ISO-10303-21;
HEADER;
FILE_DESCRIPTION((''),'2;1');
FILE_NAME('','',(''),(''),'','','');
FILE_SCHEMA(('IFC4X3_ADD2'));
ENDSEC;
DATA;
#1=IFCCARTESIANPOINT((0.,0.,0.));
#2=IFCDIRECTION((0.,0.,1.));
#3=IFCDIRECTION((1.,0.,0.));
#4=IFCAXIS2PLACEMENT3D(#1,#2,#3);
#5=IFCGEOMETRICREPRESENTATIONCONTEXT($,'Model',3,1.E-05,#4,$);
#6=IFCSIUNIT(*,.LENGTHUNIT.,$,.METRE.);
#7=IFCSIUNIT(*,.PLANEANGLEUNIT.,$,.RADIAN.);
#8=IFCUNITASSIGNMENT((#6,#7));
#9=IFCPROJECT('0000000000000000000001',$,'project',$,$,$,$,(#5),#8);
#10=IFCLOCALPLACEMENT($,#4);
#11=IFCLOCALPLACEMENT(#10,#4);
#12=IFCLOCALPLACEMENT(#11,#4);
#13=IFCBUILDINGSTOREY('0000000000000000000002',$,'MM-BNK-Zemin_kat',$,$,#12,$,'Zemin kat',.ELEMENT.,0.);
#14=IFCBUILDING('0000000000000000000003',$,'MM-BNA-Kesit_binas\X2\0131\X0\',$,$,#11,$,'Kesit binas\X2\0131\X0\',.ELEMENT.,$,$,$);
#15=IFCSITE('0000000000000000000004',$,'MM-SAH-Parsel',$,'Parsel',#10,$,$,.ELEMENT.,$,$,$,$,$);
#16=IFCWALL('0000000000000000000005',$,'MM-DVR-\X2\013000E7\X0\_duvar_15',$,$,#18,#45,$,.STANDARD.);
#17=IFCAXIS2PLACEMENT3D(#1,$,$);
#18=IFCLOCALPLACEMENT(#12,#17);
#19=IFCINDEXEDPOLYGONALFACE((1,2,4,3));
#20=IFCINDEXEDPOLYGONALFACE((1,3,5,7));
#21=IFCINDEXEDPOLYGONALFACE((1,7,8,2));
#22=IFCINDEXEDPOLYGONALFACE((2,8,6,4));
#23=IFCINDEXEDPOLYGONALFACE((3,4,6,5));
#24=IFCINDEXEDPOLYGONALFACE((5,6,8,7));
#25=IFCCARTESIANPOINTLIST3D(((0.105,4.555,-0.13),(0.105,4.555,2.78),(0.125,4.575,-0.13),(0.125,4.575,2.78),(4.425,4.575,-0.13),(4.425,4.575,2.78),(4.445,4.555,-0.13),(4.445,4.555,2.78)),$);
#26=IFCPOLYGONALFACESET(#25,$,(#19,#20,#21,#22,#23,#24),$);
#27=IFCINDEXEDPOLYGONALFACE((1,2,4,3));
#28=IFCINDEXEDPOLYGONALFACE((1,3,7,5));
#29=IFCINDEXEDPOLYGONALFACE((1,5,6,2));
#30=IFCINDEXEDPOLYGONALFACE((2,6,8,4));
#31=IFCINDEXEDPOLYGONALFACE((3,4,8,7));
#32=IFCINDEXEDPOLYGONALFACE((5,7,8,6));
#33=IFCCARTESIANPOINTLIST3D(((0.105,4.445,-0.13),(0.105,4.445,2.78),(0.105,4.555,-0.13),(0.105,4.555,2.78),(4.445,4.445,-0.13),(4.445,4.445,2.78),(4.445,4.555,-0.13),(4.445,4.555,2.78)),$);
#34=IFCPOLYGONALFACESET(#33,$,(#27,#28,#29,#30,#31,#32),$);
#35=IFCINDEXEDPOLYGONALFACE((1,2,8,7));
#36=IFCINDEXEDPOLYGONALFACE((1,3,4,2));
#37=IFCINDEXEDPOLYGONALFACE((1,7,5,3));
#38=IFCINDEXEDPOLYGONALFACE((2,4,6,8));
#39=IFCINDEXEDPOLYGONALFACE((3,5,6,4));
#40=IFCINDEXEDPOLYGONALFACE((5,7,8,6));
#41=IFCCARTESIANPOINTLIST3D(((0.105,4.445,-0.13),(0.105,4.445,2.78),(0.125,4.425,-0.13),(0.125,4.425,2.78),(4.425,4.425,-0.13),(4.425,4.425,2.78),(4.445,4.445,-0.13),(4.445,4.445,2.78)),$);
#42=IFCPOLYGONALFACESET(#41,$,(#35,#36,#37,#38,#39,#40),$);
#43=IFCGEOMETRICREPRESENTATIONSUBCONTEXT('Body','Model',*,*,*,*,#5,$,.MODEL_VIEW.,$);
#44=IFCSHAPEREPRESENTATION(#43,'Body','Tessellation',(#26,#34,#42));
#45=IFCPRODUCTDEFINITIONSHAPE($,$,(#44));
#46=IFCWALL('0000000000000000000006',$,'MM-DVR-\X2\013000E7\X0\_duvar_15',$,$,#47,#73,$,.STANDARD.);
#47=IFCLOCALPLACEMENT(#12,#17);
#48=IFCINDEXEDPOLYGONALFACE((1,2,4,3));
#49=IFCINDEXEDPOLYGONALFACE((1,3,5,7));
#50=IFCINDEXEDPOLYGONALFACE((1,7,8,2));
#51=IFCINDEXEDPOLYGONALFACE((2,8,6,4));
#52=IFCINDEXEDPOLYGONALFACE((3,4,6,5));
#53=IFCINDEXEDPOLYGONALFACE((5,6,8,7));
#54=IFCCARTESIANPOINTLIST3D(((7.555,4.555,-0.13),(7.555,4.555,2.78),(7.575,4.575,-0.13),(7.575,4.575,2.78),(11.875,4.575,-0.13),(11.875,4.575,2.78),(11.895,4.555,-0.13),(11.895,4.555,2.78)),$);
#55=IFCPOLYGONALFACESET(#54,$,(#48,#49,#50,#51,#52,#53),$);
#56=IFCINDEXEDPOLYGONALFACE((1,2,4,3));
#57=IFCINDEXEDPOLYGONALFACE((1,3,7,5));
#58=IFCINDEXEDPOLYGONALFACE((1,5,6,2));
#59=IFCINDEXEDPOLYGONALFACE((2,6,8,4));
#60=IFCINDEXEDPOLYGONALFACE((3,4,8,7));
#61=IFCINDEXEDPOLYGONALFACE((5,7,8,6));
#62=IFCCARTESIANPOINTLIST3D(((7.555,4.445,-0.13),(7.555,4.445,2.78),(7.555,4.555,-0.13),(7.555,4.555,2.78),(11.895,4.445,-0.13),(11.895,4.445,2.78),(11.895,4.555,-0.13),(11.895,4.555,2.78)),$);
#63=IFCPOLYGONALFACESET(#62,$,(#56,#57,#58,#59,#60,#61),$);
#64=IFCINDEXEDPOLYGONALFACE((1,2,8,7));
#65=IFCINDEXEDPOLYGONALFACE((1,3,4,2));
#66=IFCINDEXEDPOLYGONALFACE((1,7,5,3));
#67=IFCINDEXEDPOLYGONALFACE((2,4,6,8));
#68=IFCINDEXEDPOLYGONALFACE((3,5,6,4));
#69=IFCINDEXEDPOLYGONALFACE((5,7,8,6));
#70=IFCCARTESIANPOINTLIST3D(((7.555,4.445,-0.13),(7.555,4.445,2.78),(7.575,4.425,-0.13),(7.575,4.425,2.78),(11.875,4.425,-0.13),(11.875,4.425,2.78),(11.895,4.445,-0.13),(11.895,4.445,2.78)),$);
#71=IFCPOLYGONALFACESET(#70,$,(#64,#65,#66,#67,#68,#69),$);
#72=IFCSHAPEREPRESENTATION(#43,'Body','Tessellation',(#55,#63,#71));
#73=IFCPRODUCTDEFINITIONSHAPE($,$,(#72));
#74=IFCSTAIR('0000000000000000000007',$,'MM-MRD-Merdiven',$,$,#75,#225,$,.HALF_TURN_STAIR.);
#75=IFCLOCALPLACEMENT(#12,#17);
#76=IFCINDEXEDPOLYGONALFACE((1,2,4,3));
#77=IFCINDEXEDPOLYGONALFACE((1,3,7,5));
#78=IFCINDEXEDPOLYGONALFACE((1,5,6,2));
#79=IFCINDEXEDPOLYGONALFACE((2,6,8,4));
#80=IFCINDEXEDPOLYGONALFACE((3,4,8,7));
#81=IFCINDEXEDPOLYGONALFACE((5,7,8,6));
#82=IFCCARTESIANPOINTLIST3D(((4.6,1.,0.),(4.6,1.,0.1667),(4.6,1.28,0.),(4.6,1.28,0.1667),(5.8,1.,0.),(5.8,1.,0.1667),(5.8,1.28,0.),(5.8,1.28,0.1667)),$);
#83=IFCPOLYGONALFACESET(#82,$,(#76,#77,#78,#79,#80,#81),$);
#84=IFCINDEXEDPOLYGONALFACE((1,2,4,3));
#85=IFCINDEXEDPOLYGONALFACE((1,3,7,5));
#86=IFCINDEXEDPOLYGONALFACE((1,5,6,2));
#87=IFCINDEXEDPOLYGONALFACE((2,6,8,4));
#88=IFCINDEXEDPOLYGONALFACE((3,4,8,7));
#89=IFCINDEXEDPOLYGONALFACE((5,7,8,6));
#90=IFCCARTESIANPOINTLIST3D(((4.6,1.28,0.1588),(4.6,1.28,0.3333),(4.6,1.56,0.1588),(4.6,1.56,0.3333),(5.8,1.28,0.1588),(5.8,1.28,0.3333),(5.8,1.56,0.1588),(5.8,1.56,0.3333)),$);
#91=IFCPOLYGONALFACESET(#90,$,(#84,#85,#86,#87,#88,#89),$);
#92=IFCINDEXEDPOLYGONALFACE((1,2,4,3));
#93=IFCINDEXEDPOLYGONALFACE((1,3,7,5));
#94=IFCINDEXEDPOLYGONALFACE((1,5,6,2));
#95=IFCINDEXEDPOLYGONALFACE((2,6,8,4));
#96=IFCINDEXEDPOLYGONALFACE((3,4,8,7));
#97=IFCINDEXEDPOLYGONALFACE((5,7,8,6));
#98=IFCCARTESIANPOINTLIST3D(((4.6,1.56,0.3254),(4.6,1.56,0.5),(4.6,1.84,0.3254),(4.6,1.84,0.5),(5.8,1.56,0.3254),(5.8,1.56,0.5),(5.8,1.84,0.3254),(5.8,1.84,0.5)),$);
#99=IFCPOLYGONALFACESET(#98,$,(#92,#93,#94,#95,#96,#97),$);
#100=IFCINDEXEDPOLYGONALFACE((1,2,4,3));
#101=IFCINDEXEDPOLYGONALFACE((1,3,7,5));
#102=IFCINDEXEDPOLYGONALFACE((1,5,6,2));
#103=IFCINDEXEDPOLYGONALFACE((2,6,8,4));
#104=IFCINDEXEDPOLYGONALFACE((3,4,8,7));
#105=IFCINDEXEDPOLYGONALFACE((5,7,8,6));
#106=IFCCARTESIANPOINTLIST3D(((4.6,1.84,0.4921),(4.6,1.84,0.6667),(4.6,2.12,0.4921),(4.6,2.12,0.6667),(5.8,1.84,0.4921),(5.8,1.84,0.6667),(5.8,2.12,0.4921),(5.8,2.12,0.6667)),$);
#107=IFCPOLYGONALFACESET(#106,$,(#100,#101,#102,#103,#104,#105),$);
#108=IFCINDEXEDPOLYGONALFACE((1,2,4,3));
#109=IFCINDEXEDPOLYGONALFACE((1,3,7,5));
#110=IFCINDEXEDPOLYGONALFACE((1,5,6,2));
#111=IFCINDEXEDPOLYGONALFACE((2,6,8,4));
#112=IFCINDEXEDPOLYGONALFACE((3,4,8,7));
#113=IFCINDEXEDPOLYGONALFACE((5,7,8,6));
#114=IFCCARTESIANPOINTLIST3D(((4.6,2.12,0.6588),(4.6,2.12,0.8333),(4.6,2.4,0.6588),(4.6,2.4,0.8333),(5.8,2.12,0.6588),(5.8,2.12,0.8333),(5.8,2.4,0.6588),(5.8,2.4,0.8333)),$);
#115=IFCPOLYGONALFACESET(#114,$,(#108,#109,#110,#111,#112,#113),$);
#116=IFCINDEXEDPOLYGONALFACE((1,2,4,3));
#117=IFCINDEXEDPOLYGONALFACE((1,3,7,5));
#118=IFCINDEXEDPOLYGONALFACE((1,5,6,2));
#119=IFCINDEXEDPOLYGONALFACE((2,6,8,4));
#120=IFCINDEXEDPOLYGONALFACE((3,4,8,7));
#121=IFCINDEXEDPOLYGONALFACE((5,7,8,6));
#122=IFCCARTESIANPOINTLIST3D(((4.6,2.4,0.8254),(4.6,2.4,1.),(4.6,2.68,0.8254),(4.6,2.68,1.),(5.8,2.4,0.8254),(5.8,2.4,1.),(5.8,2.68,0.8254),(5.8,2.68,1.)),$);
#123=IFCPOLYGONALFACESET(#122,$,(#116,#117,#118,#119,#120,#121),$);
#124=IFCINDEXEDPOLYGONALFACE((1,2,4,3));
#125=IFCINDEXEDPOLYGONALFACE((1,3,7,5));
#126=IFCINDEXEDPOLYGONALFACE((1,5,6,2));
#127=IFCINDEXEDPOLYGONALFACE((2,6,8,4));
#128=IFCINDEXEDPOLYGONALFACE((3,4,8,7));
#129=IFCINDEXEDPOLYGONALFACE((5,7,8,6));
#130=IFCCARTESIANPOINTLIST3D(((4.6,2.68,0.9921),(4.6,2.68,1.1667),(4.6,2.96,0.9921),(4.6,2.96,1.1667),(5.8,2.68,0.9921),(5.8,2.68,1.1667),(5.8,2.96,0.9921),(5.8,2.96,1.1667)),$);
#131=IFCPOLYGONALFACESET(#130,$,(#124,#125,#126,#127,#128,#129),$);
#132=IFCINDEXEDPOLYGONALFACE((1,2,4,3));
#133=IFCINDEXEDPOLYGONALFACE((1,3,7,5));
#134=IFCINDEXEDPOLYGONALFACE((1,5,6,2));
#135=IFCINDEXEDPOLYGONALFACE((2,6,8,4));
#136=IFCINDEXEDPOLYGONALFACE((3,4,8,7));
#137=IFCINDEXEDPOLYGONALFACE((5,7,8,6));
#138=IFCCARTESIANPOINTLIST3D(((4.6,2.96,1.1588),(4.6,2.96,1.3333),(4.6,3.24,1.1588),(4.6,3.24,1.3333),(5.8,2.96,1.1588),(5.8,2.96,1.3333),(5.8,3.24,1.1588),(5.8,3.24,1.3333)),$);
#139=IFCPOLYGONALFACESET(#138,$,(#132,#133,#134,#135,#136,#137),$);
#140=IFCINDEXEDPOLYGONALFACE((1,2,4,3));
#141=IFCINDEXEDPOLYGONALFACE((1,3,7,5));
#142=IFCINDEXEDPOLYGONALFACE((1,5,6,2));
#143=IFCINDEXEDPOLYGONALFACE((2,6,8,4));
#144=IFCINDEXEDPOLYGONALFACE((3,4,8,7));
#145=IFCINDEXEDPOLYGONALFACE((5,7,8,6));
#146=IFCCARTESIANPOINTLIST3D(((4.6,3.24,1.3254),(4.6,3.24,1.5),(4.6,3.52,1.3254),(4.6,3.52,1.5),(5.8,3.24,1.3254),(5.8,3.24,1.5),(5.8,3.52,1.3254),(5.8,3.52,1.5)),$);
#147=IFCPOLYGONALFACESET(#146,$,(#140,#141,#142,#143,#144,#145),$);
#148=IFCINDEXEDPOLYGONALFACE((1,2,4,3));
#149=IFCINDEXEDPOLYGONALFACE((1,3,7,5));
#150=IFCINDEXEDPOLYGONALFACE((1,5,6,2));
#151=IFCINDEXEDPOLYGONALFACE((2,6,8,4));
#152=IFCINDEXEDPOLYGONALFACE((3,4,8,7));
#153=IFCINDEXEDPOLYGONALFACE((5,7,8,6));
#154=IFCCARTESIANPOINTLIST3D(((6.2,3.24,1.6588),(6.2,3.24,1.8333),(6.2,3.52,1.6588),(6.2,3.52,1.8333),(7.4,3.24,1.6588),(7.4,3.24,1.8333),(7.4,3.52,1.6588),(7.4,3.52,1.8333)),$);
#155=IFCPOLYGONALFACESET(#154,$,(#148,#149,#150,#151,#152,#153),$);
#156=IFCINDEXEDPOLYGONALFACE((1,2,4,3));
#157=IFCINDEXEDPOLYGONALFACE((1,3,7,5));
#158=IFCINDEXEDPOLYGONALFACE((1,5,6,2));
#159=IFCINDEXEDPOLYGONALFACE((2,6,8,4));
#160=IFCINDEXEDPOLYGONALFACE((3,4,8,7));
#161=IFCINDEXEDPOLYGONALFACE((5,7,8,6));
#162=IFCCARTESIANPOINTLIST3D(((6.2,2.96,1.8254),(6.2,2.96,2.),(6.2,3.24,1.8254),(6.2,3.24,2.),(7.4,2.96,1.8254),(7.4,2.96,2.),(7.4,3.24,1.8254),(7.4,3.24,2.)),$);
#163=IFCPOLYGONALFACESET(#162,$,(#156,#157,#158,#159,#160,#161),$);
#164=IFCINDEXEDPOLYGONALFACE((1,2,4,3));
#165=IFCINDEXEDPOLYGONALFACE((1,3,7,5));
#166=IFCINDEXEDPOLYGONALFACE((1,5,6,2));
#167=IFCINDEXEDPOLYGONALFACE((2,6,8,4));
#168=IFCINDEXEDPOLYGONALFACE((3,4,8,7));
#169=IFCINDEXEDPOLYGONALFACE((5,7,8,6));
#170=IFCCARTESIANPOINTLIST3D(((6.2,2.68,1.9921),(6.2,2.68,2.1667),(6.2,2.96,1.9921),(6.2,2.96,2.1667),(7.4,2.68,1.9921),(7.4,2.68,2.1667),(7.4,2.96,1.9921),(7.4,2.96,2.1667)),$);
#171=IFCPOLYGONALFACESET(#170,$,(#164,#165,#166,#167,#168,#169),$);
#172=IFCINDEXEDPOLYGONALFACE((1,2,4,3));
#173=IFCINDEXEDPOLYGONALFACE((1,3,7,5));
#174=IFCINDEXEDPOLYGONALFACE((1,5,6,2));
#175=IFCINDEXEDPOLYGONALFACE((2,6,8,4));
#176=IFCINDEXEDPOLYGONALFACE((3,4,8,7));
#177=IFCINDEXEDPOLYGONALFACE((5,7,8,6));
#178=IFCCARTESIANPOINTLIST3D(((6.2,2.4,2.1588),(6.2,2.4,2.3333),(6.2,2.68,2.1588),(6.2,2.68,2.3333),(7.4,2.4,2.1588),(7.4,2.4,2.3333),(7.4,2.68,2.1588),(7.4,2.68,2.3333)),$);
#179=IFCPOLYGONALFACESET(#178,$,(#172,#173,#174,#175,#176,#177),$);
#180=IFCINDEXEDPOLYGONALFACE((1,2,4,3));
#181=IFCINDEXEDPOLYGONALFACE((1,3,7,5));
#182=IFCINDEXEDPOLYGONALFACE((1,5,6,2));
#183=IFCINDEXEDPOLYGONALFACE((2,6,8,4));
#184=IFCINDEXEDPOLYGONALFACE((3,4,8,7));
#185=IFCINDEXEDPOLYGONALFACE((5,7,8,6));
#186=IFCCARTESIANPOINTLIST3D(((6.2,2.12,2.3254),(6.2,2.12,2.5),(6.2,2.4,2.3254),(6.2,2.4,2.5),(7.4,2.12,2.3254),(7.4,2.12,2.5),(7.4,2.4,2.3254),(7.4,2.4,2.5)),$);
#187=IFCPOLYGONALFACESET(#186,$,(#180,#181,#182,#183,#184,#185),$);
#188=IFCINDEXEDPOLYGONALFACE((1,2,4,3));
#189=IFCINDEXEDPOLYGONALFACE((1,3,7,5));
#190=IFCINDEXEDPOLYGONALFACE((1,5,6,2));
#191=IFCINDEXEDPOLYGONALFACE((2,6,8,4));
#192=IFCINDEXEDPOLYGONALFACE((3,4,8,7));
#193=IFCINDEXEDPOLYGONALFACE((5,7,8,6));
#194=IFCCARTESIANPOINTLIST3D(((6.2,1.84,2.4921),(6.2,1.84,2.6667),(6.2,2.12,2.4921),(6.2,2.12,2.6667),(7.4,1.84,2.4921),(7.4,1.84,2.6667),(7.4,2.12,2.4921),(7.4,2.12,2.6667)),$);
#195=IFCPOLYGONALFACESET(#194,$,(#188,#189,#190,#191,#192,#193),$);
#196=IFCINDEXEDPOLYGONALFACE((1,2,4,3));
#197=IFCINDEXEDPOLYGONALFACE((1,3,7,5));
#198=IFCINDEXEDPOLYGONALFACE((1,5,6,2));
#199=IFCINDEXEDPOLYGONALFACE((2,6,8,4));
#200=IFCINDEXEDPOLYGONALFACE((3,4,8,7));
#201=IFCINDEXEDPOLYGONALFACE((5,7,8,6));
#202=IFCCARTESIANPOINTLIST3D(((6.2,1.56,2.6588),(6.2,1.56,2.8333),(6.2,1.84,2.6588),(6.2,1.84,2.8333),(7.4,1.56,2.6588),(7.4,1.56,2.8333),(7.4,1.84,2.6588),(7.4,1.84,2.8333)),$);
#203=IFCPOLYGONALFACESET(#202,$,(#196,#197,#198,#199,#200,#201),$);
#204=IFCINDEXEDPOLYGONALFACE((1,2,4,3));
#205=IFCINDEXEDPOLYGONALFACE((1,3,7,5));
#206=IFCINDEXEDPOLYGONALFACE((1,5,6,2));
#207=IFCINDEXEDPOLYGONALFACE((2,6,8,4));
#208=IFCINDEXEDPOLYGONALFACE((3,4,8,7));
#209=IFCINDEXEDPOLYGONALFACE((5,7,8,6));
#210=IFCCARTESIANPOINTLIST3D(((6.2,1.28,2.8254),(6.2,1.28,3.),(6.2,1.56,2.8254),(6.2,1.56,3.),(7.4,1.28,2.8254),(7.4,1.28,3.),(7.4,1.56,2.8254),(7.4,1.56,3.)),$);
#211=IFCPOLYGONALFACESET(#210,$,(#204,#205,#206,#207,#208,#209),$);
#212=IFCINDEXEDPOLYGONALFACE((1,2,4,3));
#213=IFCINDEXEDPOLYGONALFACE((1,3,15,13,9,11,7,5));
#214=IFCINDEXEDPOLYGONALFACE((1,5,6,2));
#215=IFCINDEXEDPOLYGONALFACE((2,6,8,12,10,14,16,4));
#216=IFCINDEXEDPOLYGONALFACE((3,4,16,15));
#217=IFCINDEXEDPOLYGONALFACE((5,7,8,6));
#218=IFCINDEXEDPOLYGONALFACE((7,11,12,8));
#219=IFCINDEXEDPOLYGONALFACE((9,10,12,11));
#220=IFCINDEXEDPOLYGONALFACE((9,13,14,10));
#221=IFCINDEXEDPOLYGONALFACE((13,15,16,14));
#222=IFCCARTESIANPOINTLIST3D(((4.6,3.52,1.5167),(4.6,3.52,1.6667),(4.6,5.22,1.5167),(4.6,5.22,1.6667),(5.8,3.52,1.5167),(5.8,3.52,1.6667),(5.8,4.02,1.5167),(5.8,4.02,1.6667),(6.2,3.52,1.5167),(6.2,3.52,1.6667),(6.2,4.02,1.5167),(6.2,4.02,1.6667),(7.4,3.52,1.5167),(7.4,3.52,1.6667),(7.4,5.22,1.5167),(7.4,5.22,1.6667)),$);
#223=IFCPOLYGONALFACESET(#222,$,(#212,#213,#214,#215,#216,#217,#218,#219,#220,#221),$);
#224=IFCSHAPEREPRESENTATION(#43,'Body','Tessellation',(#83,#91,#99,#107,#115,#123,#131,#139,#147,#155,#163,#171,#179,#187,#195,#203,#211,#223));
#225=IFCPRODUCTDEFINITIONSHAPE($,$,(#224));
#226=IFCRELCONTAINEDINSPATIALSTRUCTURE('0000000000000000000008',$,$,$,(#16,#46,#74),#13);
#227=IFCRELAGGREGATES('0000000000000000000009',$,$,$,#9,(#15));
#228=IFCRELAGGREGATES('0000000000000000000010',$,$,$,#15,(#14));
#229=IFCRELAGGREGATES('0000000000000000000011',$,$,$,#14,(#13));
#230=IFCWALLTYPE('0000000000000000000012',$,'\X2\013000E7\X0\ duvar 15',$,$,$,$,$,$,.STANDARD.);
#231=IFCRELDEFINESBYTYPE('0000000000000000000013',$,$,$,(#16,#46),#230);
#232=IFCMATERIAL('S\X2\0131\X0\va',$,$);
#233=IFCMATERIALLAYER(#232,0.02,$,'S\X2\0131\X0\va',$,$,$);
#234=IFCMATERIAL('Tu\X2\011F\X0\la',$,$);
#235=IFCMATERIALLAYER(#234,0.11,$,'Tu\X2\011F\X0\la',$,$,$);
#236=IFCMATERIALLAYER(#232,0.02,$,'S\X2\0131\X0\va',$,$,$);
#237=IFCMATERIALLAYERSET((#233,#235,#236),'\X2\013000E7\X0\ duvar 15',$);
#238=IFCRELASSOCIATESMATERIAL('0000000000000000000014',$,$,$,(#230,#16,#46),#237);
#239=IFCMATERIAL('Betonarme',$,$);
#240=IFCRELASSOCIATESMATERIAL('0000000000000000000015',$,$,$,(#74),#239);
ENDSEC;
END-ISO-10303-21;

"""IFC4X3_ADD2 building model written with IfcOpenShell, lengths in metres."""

from ifc_helpers import new_model, si_unit, frame, origin, origin_with_axes, place, context, subcontext, project, spatial, polyline, outline, extrude, material, layer, layer_set, type_object, element, save


model = new_model("IFC4X3_ADD2")

# Units and contexts
model_context = context("Model", 3, precision=1e-05, world=origin_with_axes())
body_context = subcontext(model_context, "Body", "Model", "MODEL_VIEW")
ifc_project = project(units=[si_unit("LENGTHUNIT", "METRE"), si_unit("PLANEANGLEUNIT", "RADIAN")], contexts=[model_context])

# Site, building, storey
site_placement = place(None, origin_with_axes())
site = spatial("IfcSite", under=ifc_project, at=site_placement, Name="MM-SAH-Parsel", ObjectType="Parsel", CompositionType="ELEMENT")
building_placement = place(site_placement, origin_with_axes())
building = spatial("IfcBuilding", under=site, at=building_placement, Name="MM-BNA-Kesit_binası", LongName="Kesit binası", CompositionType="ELEMENT")
storey_placement = place(building_placement, origin_with_axes())
storey = spatial("IfcBuildingStorey", under=building, at=storey_placement, Name="MM-BNK-Zemin_kat", LongName="Zemin kat", CompositionType="ELEMENT", Elevation=0.0)

# Shared definitions
ifc_material_1 = material(Name="Betonarme")

# Shared definitions
ifc_material_2 = material(Name="Tuğla")

# Shared definitions
ifc_material_3 = material(Name="Sıva")
ifc_layer_1 = layer(ifc_material_3, 0.02, Name="Sıva")
ifc_layer_2 = layer(ifc_material_2, 0.11, Name="Tuğla")
ifc_layer_3 = layer(ifc_material_3, 0.02, Name="Sıva")
ifc_layer_set_1 = layer_set([ifc_layer_1, ifc_layer_2, ifc_layer_3], Name="İç duvar 15")
wall_type_1 = type_object("IfcWallType", Name="İç duvar 15", PredefinedType="STANDARD", material=ifc_layer_set_1)

# Walls
wall_1_placement = place(storey_placement, origin_with_axes())
element("IfcWall", 1, at=wall_1_placement, inside=storey, type_object=wall_type_1, material=ifc_layer_set_1, Name="MM-DVR-İç_duvar_15", PredefinedType="STANDARD", context=body_context, shape_type="SweptSolid", body=[
    extrude(outline(polyline([(0.125, 4.575), (4.425, 4.575), (4.445, 4.555), (0.105, 4.555), (0.125, 4.575)])), frame((0.0, 0.0, -0.13)), (0.0, 0.0, 1.0), 2.91),
    extrude(outline(polyline([(0.105, 4.555), (4.445, 4.555), (4.445, 4.445), (0.105, 4.445), (0.105, 4.555)])), frame((0.0, 0.0, -0.13)), (0.0, 0.0, 1.0), 2.91),
    extrude(outline(polyline([(0.105, 4.445), (4.445, 4.445), (4.425, 4.425), (0.125, 4.425), (0.105, 4.445)])), frame((0.0, 0.0, -0.13)), (0.0, 0.0, 1.0), 2.91),
])
wall_2_placement = place(storey_placement, origin_with_axes())
element("IfcWall", 2, at=wall_2_placement, inside=storey, type_object=wall_type_1, material=ifc_layer_set_1, Name="MM-DVR-İç_duvar_15", PredefinedType="STANDARD", context=body_context, shape_type="SweptSolid", body=[
    extrude(outline(polyline([(7.575, 4.575), (11.875, 4.575), (11.895, 4.555), (7.555, 4.555), (7.575, 4.575)])), frame((0.0, 0.0, -0.13)), (0.0, 0.0, 1.0), 2.91),
    extrude(outline(polyline([(7.555, 4.555), (11.895, 4.555), (11.895, 4.445), (7.555, 4.445), (7.555, 4.555)])), frame((0.0, 0.0, -0.13)), (0.0, 0.0, 1.0), 2.91),
    extrude(outline(polyline([(7.555, 4.445), (11.895, 4.445), (11.875, 4.425), (7.575, 4.425), (7.555, 4.445)])), frame((0.0, 0.0, -0.13)), (0.0, 0.0, 1.0), 2.91),
])

# Stair
stair_placement = place(storey_placement, origin_with_axes())
element("IfcStair", 3, at=stair_placement, inside=storey, material=ifc_material_1, Name="MM-MRD-Merdiven", PredefinedType="HALF_TURN_STAIR", context=body_context, shape_type="SweptSolid", body=[
    extrude(outline(polyline([(5.8, 1.0), (5.8, 1.28), (4.6, 1.28), (4.6, 1.0), (5.8, 1.0)])), origin(), (0.0, 0.0, 1.0), 0.1667),
    extrude(outline(polyline([(5.8, 1.28), (5.8, 1.56), (4.6, 1.56), (4.6, 1.28), (5.8, 1.28)])), frame((0.0, 0.0, 0.1588)), (0.0, 0.0, 1.0), 0.1746),
    extrude(outline(polyline([(5.8, 1.56), (5.8, 1.84), (4.6, 1.84), (4.6, 1.56), (5.8, 1.56)])), frame((0.0, 0.0, 0.3254)), (0.0, 0.0, 1.0), 0.1746),
    extrude(outline(polyline([(5.8, 1.84), (5.8, 2.12), (4.6, 2.12), (4.6, 1.84), (5.8, 1.84)])), frame((0.0, 0.0, 0.4921)), (0.0, 0.0, 1.0), 0.1746),
    extrude(outline(polyline([(5.8, 2.12), (5.8, 2.4), (4.6, 2.4), (4.6, 2.12), (5.8, 2.12)])), frame((0.0, 0.0, 0.6588)), (0.0, 0.0, 1.0), 0.1746),
    extrude(outline(polyline([(5.8, 2.4), (5.8, 2.68), (4.6, 2.68), (4.6, 2.4), (5.8, 2.4)])), frame((0.0, 0.0, 0.8254)), (0.0, 0.0, 1.0), 0.1746),
    extrude(outline(polyline([(5.8, 2.68), (5.8, 2.96), (4.6, 2.96), (4.6, 2.68), (5.8, 2.68)])), frame((0.0, 0.0, 0.9921)), (0.0, 0.0, 1.0), 0.1746),
    extrude(outline(polyline([(5.8, 2.96), (5.8, 3.24), (4.6, 3.24), (4.6, 2.96), (5.8, 2.96)])), frame((0.0, 0.0, 1.1588)), (0.0, 0.0, 1.0), 0.1746),
    extrude(outline(polyline([(5.8, 3.24), (5.8, 3.52), (4.6, 3.52), (4.6, 3.24), (5.8, 3.24)])), frame((0.0, 0.0, 1.3254)), (0.0, 0.0, 1.0), 0.1746),
    extrude(outline(polyline([(6.2, 3.52), (6.2, 3.24), (7.4, 3.24), (7.4, 3.52), (6.2, 3.52)])), frame((0.0, 0.0, 1.6588)), (0.0, 0.0, 1.0), 0.1746),
    extrude(outline(polyline([(6.2, 3.24), (6.2, 2.96), (7.4, 2.96), (7.4, 3.24), (6.2, 3.24)])), frame((0.0, 0.0, 1.8254)), (0.0, 0.0, 1.0), 0.1746),
    extrude(outline(polyline([(6.2, 2.96), (6.2, 2.68), (7.4, 2.68), (7.4, 2.96), (6.2, 2.96)])), frame((0.0, 0.0, 1.9921)), (0.0, 0.0, 1.0), 0.1746),
    extrude(outline(polyline([(6.2, 2.68), (6.2, 2.4), (7.4, 2.4), (7.4, 2.68), (6.2, 2.68)])), frame((0.0, 0.0, 2.1588)), (0.0, 0.0, 1.0), 0.1746),
    extrude(outline(polyline([(6.2, 2.4), (6.2, 2.12), (7.4, 2.12), (7.4, 2.4), (6.2, 2.4)])), frame((0.0, 0.0, 2.3254)), (0.0, 0.0, 1.0), 0.1746),
    extrude(outline(polyline([(6.2, 2.12), (6.2, 1.84), (7.4, 1.84), (7.4, 2.12), (6.2, 2.12)])), frame((0.0, 0.0, 2.4921)), (0.0, 0.0, 1.0), 0.1746),
    extrude(outline(polyline([(6.2, 1.84), (6.2, 1.56), (7.4, 1.56), (7.4, 1.84), (6.2, 1.84)])), frame((0.0, 0.0, 2.6588)), (0.0, 0.0, 1.0), 0.1746),
    extrude(outline(polyline([(6.2, 1.56), (6.2, 1.28), (7.4, 1.28), (7.4, 1.56), (6.2, 1.56)])), frame((0.0, 0.0, 2.8254)), (0.0, 0.0, 1.0), 0.1746),
    extrude(outline(polyline([(4.6, 3.52), (4.6, 5.22), (7.4, 5.22), (7.4, 3.52), (6.2, 3.52), (6.2, 4.02), (5.8, 4.02), (5.8, 3.52), (4.6, 3.52)])), frame((0.0, 0.0, 1.5167)), (0.0, 0.0, 1.0), 0.15),
])

save(model, "model.ifc")
